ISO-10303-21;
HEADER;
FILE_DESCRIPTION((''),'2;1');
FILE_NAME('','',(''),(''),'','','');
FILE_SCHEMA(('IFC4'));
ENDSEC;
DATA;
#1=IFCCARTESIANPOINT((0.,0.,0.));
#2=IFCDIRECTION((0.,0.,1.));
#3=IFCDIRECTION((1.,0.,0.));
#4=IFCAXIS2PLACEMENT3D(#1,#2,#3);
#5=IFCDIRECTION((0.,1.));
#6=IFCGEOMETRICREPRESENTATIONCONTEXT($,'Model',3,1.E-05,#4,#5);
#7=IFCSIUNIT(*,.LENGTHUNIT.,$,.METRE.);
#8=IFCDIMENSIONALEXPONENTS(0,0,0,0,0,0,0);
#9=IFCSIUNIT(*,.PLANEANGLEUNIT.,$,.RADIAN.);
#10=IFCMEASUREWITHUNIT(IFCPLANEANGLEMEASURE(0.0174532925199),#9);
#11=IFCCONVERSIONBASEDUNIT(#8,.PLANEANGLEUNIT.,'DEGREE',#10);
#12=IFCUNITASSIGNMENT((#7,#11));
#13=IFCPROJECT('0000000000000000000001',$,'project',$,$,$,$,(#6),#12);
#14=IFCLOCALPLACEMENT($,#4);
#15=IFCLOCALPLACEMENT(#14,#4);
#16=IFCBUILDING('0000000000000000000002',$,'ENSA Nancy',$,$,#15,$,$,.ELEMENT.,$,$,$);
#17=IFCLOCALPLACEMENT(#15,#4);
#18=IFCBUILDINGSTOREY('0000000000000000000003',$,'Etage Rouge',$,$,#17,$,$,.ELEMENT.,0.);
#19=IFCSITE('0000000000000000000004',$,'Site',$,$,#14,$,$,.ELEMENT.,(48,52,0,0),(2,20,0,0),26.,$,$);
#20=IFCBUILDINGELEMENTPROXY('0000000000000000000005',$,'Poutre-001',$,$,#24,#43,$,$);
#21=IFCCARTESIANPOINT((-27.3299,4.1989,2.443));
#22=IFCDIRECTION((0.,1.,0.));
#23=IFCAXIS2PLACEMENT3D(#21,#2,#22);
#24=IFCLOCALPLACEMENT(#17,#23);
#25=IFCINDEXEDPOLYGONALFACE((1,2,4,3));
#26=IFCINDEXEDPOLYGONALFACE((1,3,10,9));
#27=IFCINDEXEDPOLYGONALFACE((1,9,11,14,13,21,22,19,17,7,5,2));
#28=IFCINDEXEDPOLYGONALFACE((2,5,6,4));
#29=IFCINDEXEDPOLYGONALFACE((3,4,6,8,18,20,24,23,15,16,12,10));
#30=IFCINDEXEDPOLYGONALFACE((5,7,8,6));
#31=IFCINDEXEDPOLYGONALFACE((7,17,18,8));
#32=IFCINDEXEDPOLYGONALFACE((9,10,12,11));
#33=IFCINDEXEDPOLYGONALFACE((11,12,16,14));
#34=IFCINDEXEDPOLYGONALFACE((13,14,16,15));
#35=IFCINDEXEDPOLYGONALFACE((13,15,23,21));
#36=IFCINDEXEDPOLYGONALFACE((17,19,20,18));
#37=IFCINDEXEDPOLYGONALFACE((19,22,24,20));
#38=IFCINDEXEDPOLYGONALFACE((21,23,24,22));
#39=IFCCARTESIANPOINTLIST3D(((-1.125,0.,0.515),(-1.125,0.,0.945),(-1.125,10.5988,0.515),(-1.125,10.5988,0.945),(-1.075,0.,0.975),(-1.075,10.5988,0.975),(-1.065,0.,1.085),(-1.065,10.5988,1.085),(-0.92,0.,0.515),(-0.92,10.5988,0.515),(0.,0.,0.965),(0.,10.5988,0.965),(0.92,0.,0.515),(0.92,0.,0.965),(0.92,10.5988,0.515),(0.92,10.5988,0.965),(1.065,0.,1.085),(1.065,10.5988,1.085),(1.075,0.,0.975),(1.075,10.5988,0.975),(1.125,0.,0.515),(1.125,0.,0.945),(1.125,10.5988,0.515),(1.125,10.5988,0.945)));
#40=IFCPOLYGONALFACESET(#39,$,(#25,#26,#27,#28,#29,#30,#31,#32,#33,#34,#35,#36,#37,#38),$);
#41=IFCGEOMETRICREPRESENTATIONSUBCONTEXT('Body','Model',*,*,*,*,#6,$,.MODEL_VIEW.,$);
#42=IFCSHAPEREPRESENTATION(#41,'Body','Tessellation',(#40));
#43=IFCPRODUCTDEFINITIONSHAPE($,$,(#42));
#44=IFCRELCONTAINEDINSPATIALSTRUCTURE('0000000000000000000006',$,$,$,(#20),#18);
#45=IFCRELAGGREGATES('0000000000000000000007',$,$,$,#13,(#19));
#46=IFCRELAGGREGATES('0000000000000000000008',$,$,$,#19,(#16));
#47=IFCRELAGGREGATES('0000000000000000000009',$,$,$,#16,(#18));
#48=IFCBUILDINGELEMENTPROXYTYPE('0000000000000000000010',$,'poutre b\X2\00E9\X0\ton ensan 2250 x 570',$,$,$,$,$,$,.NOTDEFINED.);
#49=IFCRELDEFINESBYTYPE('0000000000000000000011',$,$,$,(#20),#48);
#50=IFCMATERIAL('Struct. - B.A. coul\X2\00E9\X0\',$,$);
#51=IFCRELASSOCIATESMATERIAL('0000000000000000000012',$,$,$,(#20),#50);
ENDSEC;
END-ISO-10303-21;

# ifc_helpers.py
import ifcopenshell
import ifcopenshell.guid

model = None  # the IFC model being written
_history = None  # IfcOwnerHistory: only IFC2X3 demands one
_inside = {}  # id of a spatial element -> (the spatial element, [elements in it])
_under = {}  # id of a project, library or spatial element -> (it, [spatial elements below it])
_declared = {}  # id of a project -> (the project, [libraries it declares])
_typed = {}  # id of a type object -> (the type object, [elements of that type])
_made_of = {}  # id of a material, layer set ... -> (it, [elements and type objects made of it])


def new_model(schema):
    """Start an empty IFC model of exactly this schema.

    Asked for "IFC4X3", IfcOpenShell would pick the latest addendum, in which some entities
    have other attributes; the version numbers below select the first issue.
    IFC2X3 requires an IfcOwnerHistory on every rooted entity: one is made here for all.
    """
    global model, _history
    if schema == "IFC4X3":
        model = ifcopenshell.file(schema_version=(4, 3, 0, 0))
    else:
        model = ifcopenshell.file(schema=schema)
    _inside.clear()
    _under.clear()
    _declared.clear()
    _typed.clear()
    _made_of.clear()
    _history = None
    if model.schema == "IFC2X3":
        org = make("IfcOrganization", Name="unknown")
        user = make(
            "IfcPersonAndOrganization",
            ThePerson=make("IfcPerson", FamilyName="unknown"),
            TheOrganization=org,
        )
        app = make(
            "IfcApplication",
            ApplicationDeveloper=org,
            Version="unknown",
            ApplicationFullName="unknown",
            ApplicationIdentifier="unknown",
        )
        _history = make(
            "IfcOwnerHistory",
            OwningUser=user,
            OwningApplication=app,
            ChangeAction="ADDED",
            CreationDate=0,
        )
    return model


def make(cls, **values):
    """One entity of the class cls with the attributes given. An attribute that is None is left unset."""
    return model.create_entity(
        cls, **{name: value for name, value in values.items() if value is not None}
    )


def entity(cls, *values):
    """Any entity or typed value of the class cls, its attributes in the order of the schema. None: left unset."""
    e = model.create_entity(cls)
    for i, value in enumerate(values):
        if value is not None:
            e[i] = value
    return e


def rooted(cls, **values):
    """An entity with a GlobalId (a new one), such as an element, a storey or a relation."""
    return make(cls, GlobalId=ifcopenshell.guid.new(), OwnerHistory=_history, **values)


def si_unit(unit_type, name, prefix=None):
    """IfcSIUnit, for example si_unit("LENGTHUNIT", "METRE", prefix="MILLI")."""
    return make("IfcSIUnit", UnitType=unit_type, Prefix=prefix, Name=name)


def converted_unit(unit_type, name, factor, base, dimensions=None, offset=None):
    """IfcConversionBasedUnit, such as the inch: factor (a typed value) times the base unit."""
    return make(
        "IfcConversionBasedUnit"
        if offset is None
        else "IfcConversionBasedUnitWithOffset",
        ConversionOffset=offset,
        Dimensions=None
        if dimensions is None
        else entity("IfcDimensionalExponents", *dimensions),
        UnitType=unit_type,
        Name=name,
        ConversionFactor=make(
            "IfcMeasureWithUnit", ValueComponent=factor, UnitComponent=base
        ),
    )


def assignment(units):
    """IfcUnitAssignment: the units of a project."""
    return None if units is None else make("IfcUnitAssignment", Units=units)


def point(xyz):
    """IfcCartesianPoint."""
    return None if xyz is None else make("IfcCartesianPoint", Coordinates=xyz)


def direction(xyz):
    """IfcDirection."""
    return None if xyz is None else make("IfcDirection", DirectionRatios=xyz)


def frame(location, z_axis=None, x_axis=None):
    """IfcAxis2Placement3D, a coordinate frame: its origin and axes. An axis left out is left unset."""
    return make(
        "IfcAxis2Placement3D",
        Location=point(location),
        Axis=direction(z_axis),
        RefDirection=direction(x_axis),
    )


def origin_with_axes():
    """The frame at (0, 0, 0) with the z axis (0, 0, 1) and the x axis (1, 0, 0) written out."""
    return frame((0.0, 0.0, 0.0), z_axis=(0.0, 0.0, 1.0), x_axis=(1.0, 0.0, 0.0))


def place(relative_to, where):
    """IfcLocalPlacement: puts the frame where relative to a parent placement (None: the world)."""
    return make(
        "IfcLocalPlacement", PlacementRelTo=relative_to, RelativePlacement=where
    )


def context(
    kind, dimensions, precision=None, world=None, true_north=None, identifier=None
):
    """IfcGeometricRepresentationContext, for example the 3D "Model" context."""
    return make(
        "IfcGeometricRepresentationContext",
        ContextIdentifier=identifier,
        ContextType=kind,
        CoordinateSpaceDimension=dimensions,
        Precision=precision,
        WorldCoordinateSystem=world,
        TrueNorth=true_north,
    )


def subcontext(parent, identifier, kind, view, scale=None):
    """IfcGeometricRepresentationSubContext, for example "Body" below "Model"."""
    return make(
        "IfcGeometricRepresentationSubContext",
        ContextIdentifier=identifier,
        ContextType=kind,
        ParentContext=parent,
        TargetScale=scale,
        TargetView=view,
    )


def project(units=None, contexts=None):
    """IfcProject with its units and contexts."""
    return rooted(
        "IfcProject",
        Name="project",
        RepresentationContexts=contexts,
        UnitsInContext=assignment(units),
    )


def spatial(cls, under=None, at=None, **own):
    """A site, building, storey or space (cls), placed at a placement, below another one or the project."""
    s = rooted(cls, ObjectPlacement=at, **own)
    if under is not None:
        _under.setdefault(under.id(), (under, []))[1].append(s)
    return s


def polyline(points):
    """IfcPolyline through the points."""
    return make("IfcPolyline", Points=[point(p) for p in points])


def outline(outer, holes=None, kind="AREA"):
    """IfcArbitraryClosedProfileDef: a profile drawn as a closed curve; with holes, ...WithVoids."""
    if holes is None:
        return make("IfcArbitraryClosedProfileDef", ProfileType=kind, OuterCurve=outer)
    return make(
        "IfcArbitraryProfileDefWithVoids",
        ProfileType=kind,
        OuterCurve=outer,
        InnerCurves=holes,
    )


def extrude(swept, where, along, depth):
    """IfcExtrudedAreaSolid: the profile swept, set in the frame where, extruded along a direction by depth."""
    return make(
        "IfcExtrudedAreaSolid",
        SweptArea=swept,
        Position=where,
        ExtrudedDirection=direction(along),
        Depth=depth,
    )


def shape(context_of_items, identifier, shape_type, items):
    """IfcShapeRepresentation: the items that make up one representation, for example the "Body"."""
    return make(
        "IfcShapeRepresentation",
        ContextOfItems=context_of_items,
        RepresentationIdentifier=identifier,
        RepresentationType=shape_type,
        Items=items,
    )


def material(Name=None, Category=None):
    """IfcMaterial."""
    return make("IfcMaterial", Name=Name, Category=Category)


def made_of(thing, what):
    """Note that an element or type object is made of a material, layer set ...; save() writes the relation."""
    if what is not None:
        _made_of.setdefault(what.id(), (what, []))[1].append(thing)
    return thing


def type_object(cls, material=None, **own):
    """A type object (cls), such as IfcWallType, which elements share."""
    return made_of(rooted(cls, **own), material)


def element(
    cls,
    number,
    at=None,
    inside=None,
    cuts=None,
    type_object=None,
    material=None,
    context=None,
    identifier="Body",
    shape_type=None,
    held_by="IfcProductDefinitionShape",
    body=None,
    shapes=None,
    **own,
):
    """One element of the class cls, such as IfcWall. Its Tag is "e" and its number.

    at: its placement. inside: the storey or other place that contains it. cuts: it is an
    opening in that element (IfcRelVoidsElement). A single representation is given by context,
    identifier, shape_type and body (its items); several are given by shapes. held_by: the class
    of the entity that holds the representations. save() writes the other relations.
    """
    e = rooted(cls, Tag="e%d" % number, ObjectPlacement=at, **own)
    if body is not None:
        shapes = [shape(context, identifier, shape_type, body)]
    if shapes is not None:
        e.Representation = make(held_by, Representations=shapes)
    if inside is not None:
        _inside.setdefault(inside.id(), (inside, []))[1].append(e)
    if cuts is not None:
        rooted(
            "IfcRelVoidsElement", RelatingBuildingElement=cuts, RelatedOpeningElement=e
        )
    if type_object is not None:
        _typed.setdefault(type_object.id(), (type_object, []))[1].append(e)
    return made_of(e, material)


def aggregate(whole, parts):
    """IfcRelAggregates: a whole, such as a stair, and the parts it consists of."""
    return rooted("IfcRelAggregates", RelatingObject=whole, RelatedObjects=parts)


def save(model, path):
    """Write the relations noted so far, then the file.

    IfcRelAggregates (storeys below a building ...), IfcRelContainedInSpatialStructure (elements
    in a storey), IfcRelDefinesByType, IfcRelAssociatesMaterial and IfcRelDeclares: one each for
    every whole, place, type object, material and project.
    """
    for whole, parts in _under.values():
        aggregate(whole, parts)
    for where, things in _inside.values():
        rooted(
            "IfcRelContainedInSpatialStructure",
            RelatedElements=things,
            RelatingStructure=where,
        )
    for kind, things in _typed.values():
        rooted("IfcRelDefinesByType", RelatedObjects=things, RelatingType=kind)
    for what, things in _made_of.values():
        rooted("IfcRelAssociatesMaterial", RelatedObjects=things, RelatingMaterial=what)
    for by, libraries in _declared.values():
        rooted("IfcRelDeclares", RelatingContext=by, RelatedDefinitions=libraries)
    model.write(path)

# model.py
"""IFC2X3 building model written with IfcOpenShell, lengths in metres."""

from ifc_helpers import new_model, entity, si_unit, converted_unit, direction, frame, origin_with_axes, place, context, subcontext, project, spatial, polyline, outline, extrude, material, type_object, element, save


model = new_model("IFC2X3")

# Units and contexts
model_context = context("Model", 3, precision=1e-05, world=origin_with_axes(), true_north=direction((0.0, 1.0)))
body_context = subcontext(model_context, "Body", "Model", "MODEL_VIEW")
ifc_project = project(units=[si_unit("LENGTHUNIT", "METRE"), converted_unit("PLANEANGLEUNIT", "DEGREE", entity("IfcPlaneAngleMeasure", 0.0174532925199), si_unit("PLANEANGLEUNIT", "RADIAN"), dimensions=[0, 0, 0, 0, 0, 0, 0])], contexts=[model_context])

# Site, building, storey
site_placement = place(None, origin_with_axes())
site = spatial("IfcSite", under=ifc_project, at=site_placement, Name="Site", CompositionType="ELEMENT", RefLatitude=(48, 52, 0, 0), RefLongitude=(2, 20, 0, 0), RefElevation=26.0)
building_placement = place(site_placement, origin_with_axes())
building = spatial("IfcBuilding", under=site, at=building_placement, Name="ENSA Nancy", CompositionType="ELEMENT")
storey_placement = place(building_placement, origin_with_axes())
storey = spatial("IfcBuildingStorey", under=building, at=storey_placement, Name="Etage Rouge", CompositionType="ELEMENT", Elevation=0.0)

# Building element proxy
ifc_material_1 = material(Name="Struct. - B.A. coulé")
building_element_proxy_type_1 = type_object("IfcBuildingElementProxyType", Name="poutre béton ensan 2250 x 570", PredefinedType="NOTDEFINED")
proxy_1_placement = place(storey_placement, frame((-27.3299, 4.1989, 2.443), z_axis=(0.0, 0.0, 1.0), x_axis=(0.0, 1.0, 0.0)))
element("IfcBuildingElementProxy", 1, at=proxy_1_placement, inside=storey, type_object=building_element_proxy_type_1, material=ifc_material_1, Name="Poutre-001", context=body_context, shape_type="SweptSolid", body=[
    extrude(outline(polyline([(-1.065, 1.085), (-1.075, 0.975), (-1.125, 0.945), (-1.125, 0.515), (-0.92, 0.515), (0.0, 0.965), (0.92, 0.965), (0.92, 0.515), (1.125, 0.515), (1.125, 0.945), (1.075, 0.975), (1.065, 1.085), (-1.065, 1.085)])), frame((0.0, 10.5988, 0.0), z_axis=(0.0, -1.0, 0.0), x_axis=(1.0, 0.0, 0.0)), (0.0, 0.0, 1.0), 10.5988),
])

save(model, "model.ifc")
